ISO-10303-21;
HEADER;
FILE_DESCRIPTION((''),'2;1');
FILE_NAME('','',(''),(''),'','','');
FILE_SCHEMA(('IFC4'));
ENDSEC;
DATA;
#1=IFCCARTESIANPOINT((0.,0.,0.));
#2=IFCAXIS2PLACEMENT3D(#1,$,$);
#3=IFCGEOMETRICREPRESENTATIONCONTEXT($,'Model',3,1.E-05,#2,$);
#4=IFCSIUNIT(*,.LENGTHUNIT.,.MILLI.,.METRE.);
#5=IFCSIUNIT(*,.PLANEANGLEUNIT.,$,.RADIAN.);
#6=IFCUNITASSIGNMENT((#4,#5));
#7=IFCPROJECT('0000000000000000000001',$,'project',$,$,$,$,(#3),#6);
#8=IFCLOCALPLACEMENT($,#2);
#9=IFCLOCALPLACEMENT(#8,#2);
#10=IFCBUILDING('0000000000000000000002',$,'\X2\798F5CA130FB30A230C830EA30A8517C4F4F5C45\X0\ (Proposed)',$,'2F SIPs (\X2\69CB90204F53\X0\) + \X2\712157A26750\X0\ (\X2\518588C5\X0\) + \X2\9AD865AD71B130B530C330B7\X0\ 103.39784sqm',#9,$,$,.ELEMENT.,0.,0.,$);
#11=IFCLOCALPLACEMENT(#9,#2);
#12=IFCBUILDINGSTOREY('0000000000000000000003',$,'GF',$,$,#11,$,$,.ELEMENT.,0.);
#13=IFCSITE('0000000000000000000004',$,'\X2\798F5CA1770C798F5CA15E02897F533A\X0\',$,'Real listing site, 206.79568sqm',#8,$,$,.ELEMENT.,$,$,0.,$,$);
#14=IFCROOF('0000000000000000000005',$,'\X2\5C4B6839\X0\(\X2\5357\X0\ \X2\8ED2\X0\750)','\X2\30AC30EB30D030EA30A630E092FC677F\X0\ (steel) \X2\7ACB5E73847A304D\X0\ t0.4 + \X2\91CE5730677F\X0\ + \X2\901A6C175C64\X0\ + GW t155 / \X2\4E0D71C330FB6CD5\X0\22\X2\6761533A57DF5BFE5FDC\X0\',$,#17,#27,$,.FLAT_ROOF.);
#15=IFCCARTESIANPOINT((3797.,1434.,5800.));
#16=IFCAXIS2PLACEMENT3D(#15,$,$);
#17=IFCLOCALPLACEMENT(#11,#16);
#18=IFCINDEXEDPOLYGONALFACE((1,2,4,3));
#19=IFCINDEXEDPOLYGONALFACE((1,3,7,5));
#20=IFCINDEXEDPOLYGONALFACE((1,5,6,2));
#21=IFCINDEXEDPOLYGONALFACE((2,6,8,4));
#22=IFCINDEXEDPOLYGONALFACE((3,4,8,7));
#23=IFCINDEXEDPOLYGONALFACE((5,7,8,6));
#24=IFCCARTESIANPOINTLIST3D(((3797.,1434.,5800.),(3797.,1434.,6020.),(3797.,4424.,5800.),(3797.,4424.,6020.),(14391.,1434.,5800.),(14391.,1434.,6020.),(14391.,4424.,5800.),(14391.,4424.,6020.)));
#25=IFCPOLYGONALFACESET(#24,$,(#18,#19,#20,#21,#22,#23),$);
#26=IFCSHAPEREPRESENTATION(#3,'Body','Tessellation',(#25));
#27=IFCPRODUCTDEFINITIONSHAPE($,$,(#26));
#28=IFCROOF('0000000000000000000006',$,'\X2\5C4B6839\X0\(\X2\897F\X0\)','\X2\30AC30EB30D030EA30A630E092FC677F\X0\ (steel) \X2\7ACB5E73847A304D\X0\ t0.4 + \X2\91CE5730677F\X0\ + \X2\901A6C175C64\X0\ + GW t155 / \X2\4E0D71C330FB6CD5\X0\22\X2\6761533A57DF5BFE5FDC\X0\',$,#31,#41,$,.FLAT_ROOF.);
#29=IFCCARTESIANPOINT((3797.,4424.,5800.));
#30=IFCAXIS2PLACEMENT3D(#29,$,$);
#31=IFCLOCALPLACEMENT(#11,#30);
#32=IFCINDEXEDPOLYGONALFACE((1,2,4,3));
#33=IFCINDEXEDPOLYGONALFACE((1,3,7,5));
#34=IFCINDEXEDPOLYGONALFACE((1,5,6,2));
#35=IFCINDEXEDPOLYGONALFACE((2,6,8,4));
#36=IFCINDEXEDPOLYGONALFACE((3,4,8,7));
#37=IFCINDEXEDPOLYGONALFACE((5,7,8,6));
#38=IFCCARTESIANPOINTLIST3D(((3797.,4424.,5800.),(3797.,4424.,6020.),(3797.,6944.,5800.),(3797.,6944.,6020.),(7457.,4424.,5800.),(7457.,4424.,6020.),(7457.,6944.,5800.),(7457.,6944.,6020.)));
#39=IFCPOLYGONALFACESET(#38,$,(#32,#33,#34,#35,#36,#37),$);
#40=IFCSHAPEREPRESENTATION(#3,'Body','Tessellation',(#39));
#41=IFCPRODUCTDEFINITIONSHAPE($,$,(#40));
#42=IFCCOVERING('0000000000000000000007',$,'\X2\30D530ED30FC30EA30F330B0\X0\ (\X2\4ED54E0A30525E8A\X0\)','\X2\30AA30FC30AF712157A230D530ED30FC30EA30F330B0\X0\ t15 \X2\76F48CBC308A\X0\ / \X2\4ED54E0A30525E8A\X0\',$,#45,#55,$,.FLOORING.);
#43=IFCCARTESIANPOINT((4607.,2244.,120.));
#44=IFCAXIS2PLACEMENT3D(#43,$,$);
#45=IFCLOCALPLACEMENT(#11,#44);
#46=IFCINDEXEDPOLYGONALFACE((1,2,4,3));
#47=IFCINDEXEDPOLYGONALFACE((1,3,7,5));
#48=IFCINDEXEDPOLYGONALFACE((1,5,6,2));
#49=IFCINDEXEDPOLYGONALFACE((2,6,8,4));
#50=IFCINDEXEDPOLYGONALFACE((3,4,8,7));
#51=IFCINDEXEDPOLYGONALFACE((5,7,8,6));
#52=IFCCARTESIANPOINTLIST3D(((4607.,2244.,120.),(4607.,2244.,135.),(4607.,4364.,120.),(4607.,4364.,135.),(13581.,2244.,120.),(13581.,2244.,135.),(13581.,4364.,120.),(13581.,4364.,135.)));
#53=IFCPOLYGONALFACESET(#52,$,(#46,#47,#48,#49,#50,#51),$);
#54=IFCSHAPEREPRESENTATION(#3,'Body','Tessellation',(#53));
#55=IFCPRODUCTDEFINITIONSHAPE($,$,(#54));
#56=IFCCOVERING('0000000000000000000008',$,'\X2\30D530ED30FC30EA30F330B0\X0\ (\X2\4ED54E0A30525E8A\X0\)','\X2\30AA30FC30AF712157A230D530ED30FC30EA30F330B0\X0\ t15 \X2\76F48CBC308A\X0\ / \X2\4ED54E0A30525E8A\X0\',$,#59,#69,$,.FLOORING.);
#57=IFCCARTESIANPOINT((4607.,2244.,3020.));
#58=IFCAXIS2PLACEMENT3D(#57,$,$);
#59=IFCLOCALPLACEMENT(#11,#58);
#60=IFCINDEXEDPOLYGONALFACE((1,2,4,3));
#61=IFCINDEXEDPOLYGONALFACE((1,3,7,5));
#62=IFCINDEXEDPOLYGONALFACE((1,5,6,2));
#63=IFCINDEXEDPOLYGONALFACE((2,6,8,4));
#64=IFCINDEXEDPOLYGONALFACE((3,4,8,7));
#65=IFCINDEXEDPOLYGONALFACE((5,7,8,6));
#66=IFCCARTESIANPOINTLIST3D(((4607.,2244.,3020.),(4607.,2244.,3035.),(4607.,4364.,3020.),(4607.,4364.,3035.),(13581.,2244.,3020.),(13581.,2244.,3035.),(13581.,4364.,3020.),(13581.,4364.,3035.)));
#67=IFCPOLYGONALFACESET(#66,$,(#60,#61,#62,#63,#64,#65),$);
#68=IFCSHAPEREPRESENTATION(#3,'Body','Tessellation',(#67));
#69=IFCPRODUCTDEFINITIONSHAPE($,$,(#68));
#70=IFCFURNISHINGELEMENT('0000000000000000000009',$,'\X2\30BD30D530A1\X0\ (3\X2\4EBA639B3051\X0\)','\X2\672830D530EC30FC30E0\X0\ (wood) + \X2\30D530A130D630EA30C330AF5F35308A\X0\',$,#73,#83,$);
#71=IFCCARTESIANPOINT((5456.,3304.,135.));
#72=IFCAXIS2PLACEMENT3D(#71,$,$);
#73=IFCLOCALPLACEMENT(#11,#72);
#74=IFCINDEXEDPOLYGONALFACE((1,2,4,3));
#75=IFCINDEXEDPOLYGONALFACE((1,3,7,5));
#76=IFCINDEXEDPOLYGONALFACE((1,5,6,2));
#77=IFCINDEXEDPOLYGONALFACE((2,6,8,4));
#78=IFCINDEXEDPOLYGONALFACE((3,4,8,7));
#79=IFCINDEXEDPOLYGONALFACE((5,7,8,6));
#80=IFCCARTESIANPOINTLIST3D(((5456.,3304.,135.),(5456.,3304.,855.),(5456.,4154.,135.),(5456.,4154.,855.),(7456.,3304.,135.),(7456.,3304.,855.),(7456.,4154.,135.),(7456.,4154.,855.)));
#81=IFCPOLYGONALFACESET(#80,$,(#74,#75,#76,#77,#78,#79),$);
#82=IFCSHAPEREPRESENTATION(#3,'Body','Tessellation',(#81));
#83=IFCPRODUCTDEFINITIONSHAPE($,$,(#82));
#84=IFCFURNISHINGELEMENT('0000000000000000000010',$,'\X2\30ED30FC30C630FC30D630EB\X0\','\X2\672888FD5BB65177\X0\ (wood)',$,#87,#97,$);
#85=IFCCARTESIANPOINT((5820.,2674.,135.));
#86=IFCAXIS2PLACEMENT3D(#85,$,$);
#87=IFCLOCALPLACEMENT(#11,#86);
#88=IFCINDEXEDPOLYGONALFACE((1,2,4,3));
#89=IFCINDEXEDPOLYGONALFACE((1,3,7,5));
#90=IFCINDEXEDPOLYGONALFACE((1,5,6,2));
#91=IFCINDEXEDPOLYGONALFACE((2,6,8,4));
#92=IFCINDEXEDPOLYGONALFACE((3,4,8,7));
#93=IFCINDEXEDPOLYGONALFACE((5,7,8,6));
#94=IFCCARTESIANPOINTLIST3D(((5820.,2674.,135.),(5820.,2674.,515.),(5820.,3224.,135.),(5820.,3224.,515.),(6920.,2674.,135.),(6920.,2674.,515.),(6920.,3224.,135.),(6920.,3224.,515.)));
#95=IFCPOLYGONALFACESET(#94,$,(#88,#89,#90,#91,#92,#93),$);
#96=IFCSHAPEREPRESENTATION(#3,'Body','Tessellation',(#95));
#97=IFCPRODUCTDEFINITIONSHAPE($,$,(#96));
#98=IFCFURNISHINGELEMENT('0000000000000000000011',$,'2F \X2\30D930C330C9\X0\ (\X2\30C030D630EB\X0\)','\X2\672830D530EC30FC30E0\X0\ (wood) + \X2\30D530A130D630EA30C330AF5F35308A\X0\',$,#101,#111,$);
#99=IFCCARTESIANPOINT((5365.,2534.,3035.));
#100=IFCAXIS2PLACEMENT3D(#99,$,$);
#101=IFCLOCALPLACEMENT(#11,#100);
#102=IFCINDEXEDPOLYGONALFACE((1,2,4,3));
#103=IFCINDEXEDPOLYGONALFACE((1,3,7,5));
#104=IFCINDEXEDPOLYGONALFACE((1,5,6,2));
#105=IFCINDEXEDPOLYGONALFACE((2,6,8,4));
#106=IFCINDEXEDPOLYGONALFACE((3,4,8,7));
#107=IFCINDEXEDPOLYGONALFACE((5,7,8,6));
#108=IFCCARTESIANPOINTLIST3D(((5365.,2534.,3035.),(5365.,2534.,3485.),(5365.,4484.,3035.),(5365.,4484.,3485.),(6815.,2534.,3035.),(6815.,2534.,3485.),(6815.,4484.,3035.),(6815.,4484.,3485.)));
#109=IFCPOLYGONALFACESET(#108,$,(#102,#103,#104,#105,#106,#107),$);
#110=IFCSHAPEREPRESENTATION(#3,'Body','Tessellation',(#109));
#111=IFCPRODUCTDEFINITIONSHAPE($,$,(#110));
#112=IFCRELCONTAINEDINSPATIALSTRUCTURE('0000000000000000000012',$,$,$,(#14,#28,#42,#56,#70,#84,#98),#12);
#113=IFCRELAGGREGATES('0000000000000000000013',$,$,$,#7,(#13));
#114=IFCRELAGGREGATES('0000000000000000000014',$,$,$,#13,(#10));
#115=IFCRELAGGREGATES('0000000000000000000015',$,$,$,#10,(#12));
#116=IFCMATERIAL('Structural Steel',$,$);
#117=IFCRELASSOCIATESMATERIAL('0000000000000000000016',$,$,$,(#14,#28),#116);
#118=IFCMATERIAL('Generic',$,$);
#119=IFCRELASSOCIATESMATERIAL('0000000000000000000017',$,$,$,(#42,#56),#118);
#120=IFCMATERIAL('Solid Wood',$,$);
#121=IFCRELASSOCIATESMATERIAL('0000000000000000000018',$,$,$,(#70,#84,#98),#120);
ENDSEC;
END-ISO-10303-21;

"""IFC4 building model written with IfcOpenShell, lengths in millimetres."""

from ifc_helpers import new_model, si_unit, frame, frame_2d, origin, place, context, project, spatial, rectangle, extrude, material, element, save


model = new_model("IFC4")

# Units and contexts
model_context = context("Model", 3, precision=1e-05, world=origin())
ifc_project = project(units=[si_unit("LENGTHUNIT", "METRE", prefix="MILLI"), si_unit("PLANEANGLEUNIT", "RADIAN")], contexts=[model_context])

# Site, building, storey
site_placement = place(None, origin())
site = spatial("IfcSite", under=ifc_project, at=site_placement, Name="福岡県福岡市西区", ObjectType="Real listing site, 206.79568sqm", CompositionType="ELEMENT", RefElevation=0.0)
building_placement = place(site_placement, origin())
building = spatial("IfcBuilding", under=site, at=building_placement, Name="福岡・アトリエ兼住居 (Proposed)", ObjectType="2F SIPs (構造体) + 無垢材 (内装) + 高断熱サッシ 103.39784sqm", CompositionType="ELEMENT", ElevationOfRefHeight=0.0, ElevationOfTerrain=0.0)
storey_placement = place(building_placement, origin())
storey = spatial("IfcBuildingStorey", under=building, at=storey_placement, Name="GF", CompositionType="ELEMENT", Elevation=0.0)

# Shared definitions
ifc_material_1 = material(Name="Solid Wood")

# Roofs
ifc_material_2 = material(Name="Structural Steel")
roof_1_placement = place(storey_placement, frame((3797.0, 1434.0, 5800.0)))
element("IfcRoof", 1, at=roof_1_placement, inside=storey, material=ifc_material_2, Name="屋根(南 軒750)", Description="ガルバリウム鋼板 (steel) 立平葺き t0.4 + 野地板 + 通気層 + GW t155 / 不燃・法22条区域対応", PredefinedType="FLAT_ROOF", context=model_context, shape_type="SweptSolid", body=[
    extrude(rectangle(XDim=10594.0, YDim=2990.0, at=frame_2d((5297.0, 1495.0))), frame((3797.0, 1434.0, 5800.0)), (0.0, 0.0, 1.0), 220.0),
])
roof_2_placement = place(storey_placement, frame((3797.0, 4424.0, 5800.0)))
element("IfcRoof", 2, at=roof_2_placement, inside=storey, material=ifc_material_2, Name="屋根(西)", Description="ガルバリウム鋼板 (steel) 立平葺き t0.4 + 野地板 + 通気層 + GW t155 / 不燃・法22条区域対応", PredefinedType="FLAT_ROOF", context=model_context, shape_type="SweptSolid", body=[
    extrude(rectangle(XDim=3660.0, YDim=2520.0, at=frame_2d((1830.0, 1260.0))), frame((3797.0, 4424.0, 5800.0)), (0.0, 0.0, 1.0), 220.0),
])

# Coverings
ifc_material_3 = material(Name="Generic")
covering_1_placement = place(storey_placement, frame((4607.0, 2244.0, 120.0)))
element("IfcCovering", 3, at=covering_1_placement, inside=storey, material=ifc_material_3, Name="フローリング (仕上げ床)", Description="オーク無垢フローリング t15 直貼り / 仕上げ床", PredefinedType="FLOORING", context=model_context, shape_type="SweptSolid", body=[
    extrude(rectangle(XDim=8974.0, YDim=2120.0, at=frame_2d((4487.0, 1060.0))), frame((4607.0, 2244.0, 120.0)), (0.0, 0.0, 1.0), 15.0),
])
covering_2_placement = place(storey_placement, frame((4607.0, 2244.0, 3020.0)))
element("IfcCovering", 4, at=covering_2_placement, inside=storey, material=ifc_material_3, Name="フローリング (仕上げ床)", Description="オーク無垢フローリング t15 直貼り / 仕上げ床", PredefinedType="FLOORING", context=model_context, shape_type="SweptSolid", body=[
    extrude(rectangle(XDim=8974.0, YDim=2120.0, at=frame_2d((4487.0, 1060.0))), frame((4607.0, 2244.0, 3020.0)), (0.0, 0.0, 1.0), 15.0),
])

# Furnishing elements
furnishing_1_placement = place(storey_placement, frame((5456.0, 3304.0, 135.0)))
element("IfcFurnishingElement", 5, at=furnishing_1_placement, inside=storey, material=ifc_material_1, Name="ソファ (3人掛け)", Description="木フレーム (wood) + ファブリック張り", context=model_context, shape_type="SweptSolid", body=[
    extrude(rectangle(XDim=2000.0, YDim=850.0, at=frame_2d((1000.0, 425.0))), frame((5456.0, 3304.0, 135.0)), (0.0, 0.0, 1.0), 720.0),
])
furnishing_2_placement = place(storey_placement, frame((5820.0, 2674.0, 135.0)))
element("IfcFurnishingElement", 6, at=furnishing_2_placement, inside=storey, material=ifc_material_1, Name="ローテーブル", Description="木製家具 (wood)", context=model_context, shape_type="SweptSolid", body=[
    extrude(rectangle(XDim=1100.0, YDim=550.0, at=frame_2d((550.0, 275.0))), frame((5820.0, 2674.0, 135.0)), (0.0, 0.0, 1.0), 380.0),
])
furnishing_3_placement = place(storey_placement, frame((5365.0, 2534.0, 3035.0)))
element("IfcFurnishingElement", 7, at=furnishing_3_placement, inside=storey, material=ifc_material_1, Name="2F ベッド (ダブル)", Description="木フレーム (wood) + ファブリック張り", context=model_context, shape_type="SweptSolid", body=[
    extrude(rectangle(XDim=1450.0, YDim=1950.0, at=frame_2d((725.0, 975.0))), frame((5365.0, 2534.0, 3035.0)), (0.0, 0.0, 1.0), 450.0),
])

save(model, "model.ifc")
